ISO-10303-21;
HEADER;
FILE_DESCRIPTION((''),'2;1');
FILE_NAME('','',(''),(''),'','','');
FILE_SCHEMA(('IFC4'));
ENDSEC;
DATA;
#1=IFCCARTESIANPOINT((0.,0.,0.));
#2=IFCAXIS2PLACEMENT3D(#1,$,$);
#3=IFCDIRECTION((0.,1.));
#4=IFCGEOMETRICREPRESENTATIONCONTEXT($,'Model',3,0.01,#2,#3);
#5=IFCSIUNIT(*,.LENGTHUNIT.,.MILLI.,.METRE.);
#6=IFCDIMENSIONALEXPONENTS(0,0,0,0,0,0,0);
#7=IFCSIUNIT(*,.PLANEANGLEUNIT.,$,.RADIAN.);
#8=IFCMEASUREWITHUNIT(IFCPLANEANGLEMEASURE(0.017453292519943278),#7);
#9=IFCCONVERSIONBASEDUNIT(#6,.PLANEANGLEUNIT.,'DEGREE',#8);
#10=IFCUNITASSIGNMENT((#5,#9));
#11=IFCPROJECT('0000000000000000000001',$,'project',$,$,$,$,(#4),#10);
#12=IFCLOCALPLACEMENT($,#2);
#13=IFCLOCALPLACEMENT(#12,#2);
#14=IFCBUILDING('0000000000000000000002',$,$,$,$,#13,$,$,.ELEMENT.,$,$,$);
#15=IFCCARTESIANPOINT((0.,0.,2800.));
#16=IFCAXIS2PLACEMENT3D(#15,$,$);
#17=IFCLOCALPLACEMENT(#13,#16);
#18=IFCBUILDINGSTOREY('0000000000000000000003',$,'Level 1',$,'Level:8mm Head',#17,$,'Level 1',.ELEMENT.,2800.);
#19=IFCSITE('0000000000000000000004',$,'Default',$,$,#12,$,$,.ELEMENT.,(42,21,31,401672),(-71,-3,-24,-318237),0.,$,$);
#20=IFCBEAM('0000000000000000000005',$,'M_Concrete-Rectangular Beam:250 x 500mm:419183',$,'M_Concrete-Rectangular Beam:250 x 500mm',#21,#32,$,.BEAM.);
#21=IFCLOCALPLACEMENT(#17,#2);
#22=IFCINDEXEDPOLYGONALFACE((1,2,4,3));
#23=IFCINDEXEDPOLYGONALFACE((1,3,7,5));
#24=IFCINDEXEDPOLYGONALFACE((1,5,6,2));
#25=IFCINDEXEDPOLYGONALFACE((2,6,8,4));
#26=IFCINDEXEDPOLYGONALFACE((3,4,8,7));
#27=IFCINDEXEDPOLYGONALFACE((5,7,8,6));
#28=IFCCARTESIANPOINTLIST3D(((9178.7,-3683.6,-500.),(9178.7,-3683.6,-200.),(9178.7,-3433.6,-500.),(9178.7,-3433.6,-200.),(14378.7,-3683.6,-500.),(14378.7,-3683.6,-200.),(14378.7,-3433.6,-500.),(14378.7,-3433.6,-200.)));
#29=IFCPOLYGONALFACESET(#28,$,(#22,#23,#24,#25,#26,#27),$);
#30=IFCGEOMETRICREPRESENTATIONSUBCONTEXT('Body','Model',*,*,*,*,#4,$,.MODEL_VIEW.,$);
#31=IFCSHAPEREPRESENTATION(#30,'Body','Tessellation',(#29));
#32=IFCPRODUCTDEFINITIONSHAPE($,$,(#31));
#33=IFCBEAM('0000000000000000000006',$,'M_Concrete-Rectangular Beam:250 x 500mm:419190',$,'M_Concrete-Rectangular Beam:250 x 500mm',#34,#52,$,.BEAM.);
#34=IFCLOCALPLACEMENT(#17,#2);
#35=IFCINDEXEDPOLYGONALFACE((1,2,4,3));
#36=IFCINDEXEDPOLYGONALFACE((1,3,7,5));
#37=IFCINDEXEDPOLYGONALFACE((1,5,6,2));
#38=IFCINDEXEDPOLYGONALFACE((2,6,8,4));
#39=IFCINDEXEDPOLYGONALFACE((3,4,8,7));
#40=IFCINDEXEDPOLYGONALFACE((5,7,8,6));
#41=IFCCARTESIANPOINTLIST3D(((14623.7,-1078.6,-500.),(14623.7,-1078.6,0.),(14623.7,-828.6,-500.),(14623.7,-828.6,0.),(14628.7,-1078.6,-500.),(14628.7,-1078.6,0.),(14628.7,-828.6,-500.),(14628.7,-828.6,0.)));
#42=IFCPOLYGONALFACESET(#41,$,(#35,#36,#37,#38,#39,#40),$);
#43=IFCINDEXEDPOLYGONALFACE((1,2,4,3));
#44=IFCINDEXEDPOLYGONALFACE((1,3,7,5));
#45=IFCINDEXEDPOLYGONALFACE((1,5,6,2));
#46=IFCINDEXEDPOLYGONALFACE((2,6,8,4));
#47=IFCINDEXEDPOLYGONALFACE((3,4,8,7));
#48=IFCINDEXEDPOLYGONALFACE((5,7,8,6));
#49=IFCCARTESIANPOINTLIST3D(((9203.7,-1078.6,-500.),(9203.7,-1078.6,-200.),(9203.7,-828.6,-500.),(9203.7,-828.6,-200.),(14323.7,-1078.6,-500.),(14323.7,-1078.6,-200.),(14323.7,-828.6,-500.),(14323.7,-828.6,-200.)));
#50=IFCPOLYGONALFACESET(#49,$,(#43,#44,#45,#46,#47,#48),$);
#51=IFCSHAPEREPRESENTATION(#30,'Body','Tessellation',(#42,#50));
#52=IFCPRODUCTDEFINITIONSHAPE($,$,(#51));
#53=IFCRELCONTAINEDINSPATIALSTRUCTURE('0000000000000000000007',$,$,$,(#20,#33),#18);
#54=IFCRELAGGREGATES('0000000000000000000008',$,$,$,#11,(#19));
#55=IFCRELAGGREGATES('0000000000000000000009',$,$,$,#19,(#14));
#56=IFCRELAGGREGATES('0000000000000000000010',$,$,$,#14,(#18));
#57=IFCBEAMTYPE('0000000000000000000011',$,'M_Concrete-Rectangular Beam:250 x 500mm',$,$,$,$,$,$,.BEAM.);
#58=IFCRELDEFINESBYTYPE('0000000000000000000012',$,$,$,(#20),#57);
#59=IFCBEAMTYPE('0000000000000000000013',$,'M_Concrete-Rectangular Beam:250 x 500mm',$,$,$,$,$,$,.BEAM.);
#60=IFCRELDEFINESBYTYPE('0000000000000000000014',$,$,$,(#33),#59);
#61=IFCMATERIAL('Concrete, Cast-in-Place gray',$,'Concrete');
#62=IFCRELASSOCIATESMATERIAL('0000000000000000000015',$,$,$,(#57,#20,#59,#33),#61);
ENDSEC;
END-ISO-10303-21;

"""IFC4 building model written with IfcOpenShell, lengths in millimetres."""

from ifc_helpers import new_model, entity, si_unit, converted_unit, direction, frame, origin, place, context, subcontext, project, spatial, indexed_curve, outline, extrude, source, transform, mapped, material, type_object, type_shapes, element, save


model = new_model("IFC4")

# Units and contexts
model_context = context("Model", 3, precision=0.01, world=origin(), true_north=direction((0.0, 1.0)))
body_context = subcontext(model_context, "Body", "Model", "MODEL_VIEW")
ifc_project = project(units=[si_unit("LENGTHUNIT", "METRE", prefix="MILLI"), converted_unit("PLANEANGLEUNIT", "DEGREE", entity("IfcPlaneAngleMeasure", 0.017453292519943278), si_unit("PLANEANGLEUNIT", "RADIAN"), dimensions=[0, 0, 0, 0, 0, 0, 0])], contexts=[model_context])

# Site, building, storey
site_placement = place(None, origin())
site = spatial("IfcSite", under=ifc_project, at=site_placement, Name="Default", CompositionType="ELEMENT", RefLatitude=(42, 21, 31, 401672), RefLongitude=(-71, -3, -24, -318237), RefElevation=0.0)
building_placement = place(site_placement, origin())
building = spatial("IfcBuilding", under=site, at=building_placement, CompositionType="ELEMENT")
storey_placement = place(building_placement, frame((0.0, 0.0, 2800.0)))
storey = spatial("IfcBuildingStorey", under=building, at=storey_placement, Name="Level 1", ObjectType="Level:8mm Head", LongName="Level 1", CompositionType="ELEMENT", Elevation=2800.0)

# Shared definitions
ifc_material_1 = material(Name="Concrete, Cast-in-Place gray", Category="Concrete")

# Beams
beam_type_1 = type_object("IfcBeamType", Name="M_Concrete-Rectangular Beam:250 x 500mm", PredefinedType="BEAM", material=ifc_material_1)
shared_shape_1 = source(origin(), body_context, "Body", "SweptSolid", [
    extrude(outline(indexed_curve([(-150.0, -125.0), (150.0, -125.0), (150.0, 125.0), (-150.0, 125.0), (-150.0, -125.0)], self_intersect=False)), frame((9178.7, -3558.6, 2450.0), z_axis=(1.0, 0.0, 0.0), x_axis=(0.0, 0.0, -1.0)), (0.0, 0.0, 1.0), 5200.0),
])
type_shapes(beam_type_1, [shared_shape_1])
beam_1_placement = place(storey_placement, frame((0.0, 0.0, -2800.0)))
element("IfcBeam", 1, at=beam_1_placement, inside=storey, type_object=beam_type_1, material=ifc_material_1, Name="M_Concrete-Rectangular Beam:250 x 500mm:419183", ObjectType="M_Concrete-Rectangular Beam:250 x 500mm", PredefinedType="BEAM", context=body_context, shape_type="MappedRepresentation", body=[
    mapped(shared_shape_1, transform((0.0, 0.0, 0.0), scale=1.0)),
])
beam_type_2 = type_object("IfcBeamType", Name="M_Concrete-Rectangular Beam:250 x 500mm", PredefinedType="BEAM", material=ifc_material_1)
shared_shape_2 = source(origin(), body_context, "Body", "SweptSolid", [
    extrude(outline(indexed_curve([(-250.0, -125.0), (250.0, -125.0), (250.0, 125.0), (-250.0, 125.0), (-250.0, -125.0)], self_intersect=False)), frame((14623.7, -953.6, 2550.0), z_axis=(1.0, 0.0, 0.0), x_axis=(0.0, 0.0, -1.0)), (0.0, 0.0, 1.0), 5.0),
    extrude(outline(indexed_curve([(-150.0, -125.0), (150.0, -125.0), (150.0, 125.0), (-150.0, 125.0), (-150.0, -125.0)], self_intersect=False)), frame((9203.7, -953.6, 2450.0), z_axis=(1.0, 0.0, 0.0), x_axis=(0.0, 0.0, -1.0)), (0.0, 0.0, 1.0), 5120.0),
])
type_shapes(beam_type_2, [shared_shape_2])
beam_2_placement = place(storey_placement, frame((0.0, 0.0, -2800.0)))
element("IfcBeam", 2, at=beam_2_placement, inside=storey, type_object=beam_type_2, material=ifc_material_1, Name="M_Concrete-Rectangular Beam:250 x 500mm:419190", ObjectType="M_Concrete-Rectangular Beam:250 x 500mm", PredefinedType="BEAM", context=body_context, shape_type="MappedRepresentation", body=[
    mapped(shared_shape_2, transform((0.0, 0.0, 0.0), scale=1.0)),
])

save(model, "model.ifc")
